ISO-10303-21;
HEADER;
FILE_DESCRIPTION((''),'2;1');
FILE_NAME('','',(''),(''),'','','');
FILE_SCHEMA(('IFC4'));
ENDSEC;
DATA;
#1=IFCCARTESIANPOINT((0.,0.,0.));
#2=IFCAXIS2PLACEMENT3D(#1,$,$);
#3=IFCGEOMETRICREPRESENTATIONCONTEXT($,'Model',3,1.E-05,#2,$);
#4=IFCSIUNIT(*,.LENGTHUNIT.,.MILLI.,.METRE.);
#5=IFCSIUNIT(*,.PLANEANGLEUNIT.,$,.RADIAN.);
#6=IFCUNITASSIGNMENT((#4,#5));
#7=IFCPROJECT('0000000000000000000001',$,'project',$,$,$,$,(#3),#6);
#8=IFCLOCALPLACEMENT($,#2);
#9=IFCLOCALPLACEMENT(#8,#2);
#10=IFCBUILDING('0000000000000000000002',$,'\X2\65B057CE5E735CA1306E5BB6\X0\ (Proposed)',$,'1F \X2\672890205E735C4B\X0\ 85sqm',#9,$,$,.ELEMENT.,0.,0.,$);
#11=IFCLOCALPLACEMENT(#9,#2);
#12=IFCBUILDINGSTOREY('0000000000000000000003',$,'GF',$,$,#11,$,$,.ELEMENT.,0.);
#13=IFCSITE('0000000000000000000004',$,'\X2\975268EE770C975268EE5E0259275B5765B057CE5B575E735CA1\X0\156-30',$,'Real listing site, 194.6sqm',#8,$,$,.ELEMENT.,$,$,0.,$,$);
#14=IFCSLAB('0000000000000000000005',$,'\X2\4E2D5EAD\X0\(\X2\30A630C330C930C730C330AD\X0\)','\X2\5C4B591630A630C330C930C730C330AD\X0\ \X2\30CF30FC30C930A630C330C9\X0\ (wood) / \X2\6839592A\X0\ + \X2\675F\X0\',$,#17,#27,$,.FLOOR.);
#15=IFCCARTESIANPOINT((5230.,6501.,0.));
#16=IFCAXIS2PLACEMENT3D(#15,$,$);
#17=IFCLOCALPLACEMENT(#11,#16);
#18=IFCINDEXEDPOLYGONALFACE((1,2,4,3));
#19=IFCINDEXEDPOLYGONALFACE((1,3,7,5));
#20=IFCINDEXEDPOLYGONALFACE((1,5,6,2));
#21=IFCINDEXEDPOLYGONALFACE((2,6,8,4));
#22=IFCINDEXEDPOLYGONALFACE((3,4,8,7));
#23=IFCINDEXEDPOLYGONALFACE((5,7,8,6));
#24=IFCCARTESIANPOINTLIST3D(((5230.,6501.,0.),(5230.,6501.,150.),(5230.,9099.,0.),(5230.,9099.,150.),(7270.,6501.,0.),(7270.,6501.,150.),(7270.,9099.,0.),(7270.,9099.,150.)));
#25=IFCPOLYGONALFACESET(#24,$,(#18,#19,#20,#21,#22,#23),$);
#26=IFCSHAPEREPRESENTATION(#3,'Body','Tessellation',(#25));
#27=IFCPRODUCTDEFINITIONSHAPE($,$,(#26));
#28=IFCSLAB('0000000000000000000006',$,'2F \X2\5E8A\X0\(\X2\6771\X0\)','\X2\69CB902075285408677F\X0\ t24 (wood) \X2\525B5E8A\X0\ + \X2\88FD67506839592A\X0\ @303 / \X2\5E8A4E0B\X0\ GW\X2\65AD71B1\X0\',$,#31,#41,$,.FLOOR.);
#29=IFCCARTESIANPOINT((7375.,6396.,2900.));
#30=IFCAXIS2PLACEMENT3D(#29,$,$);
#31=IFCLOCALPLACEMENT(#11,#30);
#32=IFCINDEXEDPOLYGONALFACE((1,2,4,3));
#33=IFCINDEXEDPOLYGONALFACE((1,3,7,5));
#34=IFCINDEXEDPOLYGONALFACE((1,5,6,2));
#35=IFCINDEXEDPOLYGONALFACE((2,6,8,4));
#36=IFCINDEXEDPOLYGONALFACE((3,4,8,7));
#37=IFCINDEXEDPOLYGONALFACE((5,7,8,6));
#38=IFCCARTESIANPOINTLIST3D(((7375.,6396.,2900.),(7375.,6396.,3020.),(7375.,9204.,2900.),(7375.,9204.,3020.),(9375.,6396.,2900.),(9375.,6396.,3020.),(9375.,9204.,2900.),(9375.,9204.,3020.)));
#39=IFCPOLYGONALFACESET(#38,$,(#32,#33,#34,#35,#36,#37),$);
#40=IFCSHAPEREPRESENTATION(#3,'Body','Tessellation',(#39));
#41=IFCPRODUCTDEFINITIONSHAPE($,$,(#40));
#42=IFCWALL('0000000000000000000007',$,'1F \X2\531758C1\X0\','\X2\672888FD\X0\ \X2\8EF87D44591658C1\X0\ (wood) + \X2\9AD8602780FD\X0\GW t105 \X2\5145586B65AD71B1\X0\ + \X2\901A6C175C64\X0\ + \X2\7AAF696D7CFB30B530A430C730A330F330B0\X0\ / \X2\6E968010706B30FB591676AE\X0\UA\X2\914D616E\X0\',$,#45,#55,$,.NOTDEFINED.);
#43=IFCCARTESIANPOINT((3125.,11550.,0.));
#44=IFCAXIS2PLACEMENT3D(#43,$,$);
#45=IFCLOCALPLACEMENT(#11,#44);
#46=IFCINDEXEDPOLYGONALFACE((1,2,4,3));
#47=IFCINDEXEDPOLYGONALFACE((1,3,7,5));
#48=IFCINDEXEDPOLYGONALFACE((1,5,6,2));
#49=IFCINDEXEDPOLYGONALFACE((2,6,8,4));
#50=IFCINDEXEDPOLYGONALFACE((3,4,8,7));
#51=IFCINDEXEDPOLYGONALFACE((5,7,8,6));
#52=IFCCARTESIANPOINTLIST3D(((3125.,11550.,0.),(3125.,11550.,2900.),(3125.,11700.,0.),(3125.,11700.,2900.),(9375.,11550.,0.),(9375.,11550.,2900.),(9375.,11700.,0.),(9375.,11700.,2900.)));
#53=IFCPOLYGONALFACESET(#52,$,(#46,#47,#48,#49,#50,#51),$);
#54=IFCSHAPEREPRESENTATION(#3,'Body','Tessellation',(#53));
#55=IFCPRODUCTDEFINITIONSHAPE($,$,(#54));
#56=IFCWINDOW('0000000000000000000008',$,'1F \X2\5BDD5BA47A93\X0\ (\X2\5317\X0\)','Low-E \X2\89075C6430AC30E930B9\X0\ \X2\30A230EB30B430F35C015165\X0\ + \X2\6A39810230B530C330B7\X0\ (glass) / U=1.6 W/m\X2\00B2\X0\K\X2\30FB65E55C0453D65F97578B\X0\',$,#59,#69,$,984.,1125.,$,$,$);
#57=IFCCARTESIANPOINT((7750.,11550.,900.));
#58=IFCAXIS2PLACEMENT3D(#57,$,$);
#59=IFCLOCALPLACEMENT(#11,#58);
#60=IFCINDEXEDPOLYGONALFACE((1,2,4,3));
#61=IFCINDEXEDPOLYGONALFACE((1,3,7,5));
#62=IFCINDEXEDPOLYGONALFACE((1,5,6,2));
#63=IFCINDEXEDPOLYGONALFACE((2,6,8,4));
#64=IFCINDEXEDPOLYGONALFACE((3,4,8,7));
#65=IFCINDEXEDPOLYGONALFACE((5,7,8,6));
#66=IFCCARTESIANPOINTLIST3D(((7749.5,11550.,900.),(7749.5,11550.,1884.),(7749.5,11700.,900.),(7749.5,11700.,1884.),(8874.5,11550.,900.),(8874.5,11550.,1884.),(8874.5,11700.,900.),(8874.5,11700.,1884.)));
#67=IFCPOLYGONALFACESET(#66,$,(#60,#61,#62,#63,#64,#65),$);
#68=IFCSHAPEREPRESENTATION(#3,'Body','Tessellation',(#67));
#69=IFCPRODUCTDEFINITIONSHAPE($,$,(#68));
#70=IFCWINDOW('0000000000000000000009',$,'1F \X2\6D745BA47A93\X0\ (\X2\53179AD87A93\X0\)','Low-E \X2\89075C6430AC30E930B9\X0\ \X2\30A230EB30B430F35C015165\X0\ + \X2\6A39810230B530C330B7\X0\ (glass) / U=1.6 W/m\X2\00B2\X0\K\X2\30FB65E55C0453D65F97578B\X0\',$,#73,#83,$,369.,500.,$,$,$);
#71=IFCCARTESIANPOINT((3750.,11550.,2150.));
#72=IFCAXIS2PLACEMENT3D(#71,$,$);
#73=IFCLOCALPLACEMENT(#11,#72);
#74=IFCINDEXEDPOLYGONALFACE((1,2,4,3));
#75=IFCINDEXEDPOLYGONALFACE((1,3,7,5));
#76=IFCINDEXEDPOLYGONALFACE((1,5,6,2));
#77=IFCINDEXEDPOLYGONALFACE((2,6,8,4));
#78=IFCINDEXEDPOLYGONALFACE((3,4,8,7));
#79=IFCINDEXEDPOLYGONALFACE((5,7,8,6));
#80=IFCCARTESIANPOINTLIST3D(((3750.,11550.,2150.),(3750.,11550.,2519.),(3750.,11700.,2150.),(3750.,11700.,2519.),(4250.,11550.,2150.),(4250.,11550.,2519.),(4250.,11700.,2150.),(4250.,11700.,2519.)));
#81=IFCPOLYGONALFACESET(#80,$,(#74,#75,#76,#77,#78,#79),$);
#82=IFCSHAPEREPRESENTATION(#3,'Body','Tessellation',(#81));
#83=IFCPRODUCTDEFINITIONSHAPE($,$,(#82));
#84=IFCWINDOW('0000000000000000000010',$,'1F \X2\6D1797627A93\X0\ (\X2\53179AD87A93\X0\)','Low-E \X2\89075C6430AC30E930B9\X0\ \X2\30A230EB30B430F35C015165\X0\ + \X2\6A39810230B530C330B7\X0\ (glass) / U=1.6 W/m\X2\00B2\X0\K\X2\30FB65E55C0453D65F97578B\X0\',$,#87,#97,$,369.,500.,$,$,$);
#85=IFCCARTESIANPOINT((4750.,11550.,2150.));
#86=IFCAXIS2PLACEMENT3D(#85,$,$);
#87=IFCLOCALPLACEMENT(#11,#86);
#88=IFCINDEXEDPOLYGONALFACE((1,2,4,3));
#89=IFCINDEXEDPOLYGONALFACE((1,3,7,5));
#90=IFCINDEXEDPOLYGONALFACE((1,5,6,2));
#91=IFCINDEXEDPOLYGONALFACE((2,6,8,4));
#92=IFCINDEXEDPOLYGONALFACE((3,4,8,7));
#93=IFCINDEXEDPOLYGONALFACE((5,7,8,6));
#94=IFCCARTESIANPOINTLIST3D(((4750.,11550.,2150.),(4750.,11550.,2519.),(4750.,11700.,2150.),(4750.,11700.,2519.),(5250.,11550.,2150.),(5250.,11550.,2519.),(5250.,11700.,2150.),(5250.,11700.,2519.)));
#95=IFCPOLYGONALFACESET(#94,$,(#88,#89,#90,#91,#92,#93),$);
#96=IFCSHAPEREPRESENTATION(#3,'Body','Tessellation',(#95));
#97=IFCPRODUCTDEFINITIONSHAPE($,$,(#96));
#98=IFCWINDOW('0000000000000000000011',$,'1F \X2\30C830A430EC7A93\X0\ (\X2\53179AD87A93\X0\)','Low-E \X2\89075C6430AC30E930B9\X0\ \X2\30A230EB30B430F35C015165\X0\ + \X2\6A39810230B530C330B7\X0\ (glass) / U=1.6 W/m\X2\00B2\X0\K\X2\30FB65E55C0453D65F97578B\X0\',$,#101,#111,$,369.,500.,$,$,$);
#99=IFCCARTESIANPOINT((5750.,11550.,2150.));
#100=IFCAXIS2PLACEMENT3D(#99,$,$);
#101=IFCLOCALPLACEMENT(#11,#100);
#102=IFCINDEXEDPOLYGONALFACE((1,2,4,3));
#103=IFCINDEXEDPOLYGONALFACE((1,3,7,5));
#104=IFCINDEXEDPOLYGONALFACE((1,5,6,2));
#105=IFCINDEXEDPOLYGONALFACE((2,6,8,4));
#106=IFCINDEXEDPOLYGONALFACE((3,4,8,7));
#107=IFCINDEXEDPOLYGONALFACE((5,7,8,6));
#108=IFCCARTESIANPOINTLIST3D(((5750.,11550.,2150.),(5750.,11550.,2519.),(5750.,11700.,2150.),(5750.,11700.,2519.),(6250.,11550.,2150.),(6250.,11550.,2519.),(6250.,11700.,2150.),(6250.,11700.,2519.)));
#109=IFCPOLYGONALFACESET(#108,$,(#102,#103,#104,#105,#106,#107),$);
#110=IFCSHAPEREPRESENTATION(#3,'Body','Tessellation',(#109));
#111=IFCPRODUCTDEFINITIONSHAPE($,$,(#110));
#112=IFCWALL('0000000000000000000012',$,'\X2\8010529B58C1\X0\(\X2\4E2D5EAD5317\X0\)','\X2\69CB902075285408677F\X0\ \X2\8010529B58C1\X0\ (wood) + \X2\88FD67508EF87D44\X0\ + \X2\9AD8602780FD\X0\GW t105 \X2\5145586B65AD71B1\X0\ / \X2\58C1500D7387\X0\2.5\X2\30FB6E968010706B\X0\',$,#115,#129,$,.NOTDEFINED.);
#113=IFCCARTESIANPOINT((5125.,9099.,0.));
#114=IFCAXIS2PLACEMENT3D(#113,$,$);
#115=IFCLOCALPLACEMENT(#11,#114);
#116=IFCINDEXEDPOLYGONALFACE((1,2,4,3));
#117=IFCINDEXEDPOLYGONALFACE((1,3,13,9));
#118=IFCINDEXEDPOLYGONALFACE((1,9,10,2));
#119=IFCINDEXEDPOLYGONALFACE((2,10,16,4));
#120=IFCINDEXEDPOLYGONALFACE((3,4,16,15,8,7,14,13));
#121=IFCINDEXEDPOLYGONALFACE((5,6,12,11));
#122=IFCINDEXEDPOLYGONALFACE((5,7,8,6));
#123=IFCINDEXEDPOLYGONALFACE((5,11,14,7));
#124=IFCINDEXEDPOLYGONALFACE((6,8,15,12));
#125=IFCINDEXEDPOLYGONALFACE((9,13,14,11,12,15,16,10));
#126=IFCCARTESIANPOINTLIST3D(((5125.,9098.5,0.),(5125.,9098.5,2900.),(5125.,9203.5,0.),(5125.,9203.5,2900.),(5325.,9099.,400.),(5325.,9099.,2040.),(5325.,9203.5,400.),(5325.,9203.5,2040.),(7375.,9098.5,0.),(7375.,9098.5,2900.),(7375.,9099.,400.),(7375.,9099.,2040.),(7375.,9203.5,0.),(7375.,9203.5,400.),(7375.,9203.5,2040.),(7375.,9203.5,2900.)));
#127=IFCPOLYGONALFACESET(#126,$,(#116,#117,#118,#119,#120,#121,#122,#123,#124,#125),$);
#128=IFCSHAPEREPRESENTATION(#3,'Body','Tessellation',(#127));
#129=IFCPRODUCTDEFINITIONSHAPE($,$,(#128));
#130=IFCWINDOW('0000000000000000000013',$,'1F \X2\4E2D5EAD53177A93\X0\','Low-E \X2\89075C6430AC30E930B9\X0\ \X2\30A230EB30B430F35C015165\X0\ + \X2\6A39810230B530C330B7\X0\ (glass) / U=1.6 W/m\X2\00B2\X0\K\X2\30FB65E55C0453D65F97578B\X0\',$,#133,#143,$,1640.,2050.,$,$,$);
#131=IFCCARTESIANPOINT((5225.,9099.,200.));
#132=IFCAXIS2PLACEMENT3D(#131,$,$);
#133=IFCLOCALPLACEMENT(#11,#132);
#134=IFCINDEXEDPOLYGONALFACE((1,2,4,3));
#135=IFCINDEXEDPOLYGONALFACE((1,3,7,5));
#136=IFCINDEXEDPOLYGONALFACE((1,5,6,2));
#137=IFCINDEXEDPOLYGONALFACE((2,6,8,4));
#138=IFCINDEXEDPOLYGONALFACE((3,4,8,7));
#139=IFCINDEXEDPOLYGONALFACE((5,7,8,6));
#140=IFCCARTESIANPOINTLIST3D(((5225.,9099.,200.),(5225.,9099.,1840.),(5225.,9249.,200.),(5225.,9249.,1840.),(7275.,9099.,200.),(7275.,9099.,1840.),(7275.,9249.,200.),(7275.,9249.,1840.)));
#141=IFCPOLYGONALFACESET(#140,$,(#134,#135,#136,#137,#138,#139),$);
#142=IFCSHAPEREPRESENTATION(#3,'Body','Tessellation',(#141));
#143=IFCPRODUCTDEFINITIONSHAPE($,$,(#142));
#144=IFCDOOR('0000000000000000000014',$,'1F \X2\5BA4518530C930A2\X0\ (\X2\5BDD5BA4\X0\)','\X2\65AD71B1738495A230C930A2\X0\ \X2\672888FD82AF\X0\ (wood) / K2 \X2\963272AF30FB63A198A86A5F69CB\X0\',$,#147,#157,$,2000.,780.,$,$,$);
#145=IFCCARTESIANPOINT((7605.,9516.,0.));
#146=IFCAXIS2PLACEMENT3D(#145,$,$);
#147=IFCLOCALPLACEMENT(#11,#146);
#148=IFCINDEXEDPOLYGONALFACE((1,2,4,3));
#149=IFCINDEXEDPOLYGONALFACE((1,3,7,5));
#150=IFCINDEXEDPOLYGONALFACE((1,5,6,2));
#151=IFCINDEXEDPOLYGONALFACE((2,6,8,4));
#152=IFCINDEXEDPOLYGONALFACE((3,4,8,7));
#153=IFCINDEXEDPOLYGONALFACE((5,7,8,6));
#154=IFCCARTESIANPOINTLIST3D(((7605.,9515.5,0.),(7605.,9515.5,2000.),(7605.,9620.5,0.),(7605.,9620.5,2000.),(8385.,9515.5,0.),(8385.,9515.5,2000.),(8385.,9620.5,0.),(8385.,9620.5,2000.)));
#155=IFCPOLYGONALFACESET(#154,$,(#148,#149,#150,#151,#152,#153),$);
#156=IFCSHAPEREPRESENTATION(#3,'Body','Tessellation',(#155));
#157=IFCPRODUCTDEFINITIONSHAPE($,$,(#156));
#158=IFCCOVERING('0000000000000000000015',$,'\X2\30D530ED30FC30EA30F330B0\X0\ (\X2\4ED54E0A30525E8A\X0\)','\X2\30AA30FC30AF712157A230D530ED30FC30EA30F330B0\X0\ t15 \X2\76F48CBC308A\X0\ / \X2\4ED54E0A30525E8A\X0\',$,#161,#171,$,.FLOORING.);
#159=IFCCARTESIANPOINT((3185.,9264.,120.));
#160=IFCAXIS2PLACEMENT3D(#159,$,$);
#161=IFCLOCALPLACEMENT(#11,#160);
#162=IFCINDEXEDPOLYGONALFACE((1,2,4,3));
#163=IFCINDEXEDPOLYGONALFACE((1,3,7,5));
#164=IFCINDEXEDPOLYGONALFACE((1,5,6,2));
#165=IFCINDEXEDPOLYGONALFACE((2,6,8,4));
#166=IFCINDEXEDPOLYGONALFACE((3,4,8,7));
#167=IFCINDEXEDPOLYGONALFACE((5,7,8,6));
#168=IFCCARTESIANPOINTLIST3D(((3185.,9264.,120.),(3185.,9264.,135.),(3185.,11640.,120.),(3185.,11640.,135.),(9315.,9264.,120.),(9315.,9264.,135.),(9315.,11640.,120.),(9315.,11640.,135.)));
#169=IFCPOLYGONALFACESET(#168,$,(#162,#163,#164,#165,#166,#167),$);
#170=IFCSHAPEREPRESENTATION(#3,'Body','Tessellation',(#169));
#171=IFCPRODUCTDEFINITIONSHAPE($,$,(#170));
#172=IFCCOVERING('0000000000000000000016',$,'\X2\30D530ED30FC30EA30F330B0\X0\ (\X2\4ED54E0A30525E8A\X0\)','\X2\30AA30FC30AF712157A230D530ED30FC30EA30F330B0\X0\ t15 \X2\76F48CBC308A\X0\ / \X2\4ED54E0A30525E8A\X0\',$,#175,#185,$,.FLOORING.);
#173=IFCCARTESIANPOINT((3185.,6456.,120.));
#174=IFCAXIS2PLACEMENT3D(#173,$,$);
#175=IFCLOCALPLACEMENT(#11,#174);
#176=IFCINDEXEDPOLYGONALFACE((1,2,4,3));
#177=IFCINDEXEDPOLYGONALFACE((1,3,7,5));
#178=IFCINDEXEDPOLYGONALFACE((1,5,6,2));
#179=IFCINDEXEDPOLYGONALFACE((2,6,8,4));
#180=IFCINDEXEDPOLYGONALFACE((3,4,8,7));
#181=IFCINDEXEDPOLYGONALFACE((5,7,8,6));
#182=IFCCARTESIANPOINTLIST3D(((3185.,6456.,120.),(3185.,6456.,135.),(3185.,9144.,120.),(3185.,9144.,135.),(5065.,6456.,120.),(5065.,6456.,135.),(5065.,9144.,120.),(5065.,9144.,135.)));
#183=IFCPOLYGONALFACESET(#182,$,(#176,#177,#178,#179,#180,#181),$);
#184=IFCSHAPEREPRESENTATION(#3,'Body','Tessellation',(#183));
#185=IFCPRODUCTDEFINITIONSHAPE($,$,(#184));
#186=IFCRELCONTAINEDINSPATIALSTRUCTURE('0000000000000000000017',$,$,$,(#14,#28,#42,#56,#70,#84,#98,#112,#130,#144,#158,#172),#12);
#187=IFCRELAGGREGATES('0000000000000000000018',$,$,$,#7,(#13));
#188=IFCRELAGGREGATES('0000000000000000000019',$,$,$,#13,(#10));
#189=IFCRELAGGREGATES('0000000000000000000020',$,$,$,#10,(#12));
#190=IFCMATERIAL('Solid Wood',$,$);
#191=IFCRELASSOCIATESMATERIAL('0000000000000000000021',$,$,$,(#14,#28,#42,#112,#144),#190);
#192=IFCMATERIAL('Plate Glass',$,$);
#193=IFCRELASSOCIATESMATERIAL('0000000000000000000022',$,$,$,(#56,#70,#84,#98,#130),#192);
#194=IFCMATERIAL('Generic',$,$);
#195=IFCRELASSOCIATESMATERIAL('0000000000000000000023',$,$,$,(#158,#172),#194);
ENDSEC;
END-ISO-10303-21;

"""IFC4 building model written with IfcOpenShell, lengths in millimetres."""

from ifc_helpers import new_model, si_unit, frame, frame_2d, origin, place, context, project, spatial, rectangle, extrude, material, element, fill, save


model = new_model("IFC4")

# Units and contexts
model_context = context("Model", 3, precision=1e-05, world=origin())
ifc_project = project(units=[si_unit("LENGTHUNIT", "METRE", prefix="MILLI"), si_unit("PLANEANGLEUNIT", "RADIAN")], contexts=[model_context])

# Site, building, storey
site_placement = place(None, origin())
site = spatial("IfcSite", under=ifc_project, at=site_placement, Name="青森県青森市大字新城字平岡156-30", ObjectType="Real listing site, 194.6sqm", CompositionType="ELEMENT", RefElevation=0.0)
building_placement = place(site_placement, origin())
building = spatial("IfcBuilding", under=site, at=building_placement, Name="新城平岡の家 (Proposed)", ObjectType="1F 木造平屋 85sqm", CompositionType="ELEMENT", ElevationOfRefHeight=0.0, ElevationOfTerrain=0.0)
storey_placement = place(building_placement, origin())
storey = spatial("IfcBuildingStorey", under=building, at=storey_placement, Name="GF", CompositionType="ELEMENT", Elevation=0.0)

# Slabs
ifc_material_1 = material(Name="Solid Wood")
slab_1_placement = place(storey_placement, frame((5230.0, 6501.0, 0.0)))
element("IfcSlab", 1, at=slab_1_placement, inside=storey, material=ifc_material_1, Name="中庭(ウッドデッキ)", Description="屋外ウッドデッキ ハードウッド (wood) / 根太 + 束", PredefinedType="FLOOR", context=model_context, shape_type="SweptSolid", body=[
    extrude(rectangle(XDim=2040.0, YDim=2598.0, at=frame_2d((1020.0, 1299.0))), frame((5230.0, 6501.0, 0.0)), (0.0, 0.0, 1.0), 150.0),
])
slab_2_placement = place(storey_placement, frame((7375.0, 6396.0, 2900.0)))
element("IfcSlab", 2, at=slab_2_placement, inside=storey, material=ifc_material_1, Name="2F 床(東)", Description="構造用合板 t24 (wood) 剛床 + 製材根太 @303 / 床下 GW断熱", PredefinedType="FLOOR", context=model_context, shape_type="SweptSolid", body=[
    extrude(rectangle(XDim=2000.0, YDim=2808.0, at=frame_2d((1000.0, 1404.0))), frame((7375.0, 6396.0, 2900.0)), (0.0, 0.0, 1.0), 120.0),
])

# Wall, openings, windows
wall_1_placement = place(storey_placement, frame((3125.0, 11550.0, 0.0)))
wall_1 = element("IfcWall", 3, at=wall_1_placement, inside=storey, material=ifc_material_1, Name="1F 北壁", Description="木製 軸組外壁 (wood) + 高性能GW t105 充填断熱 + 通気層 + 窯業系サイディング / 準耐火・外皮UA配慮", PredefinedType="NOTDEFINED", context=model_context, shape_type="SweptSolid", body=[
    extrude(rectangle(XDim=6250.0, YDim=150.0, at=frame_2d((3125.0, 75.0))), frame((3125.0, 11550.0, 0.0)), (0.0, 0.0, 1.0), 2900.0),
])
opening_1_placement = place(storey_placement, frame((7750.0, 11550.0, 900.0)))
opening_1 = element("IfcOpeningElement", 4, at=opening_1_placement, cuts=wall_1, PredefinedType="NOTDEFINED", context=model_context, shape_type="SweptSolid", body=[
    extrude(rectangle(XDim=1125.0, YDim=150.0, at=frame_2d((562.0, 75.0))), frame((7750.0, 11550.0, 900.0)), (0.0, 0.0, 1.0), 984.0),
])
opening_2_placement = place(storey_placement, frame((3750.0, 11550.0, 2150.0)))
opening_2 = element("IfcOpeningElement", 5, at=opening_2_placement, cuts=wall_1, PredefinedType="NOTDEFINED", context=model_context, shape_type="SweptSolid", body=[
    extrude(rectangle(XDim=500.0, YDim=150.0, at=frame_2d((250.0, 75.0))), frame((3750.0, 11550.0, 2150.0)), (0.0, 0.0, 1.0), 369.0),
])
opening_3_placement = place(storey_placement, frame((4750.0, 11550.0, 2150.0)))
opening_3 = element("IfcOpeningElement", 6, at=opening_3_placement, cuts=wall_1, PredefinedType="NOTDEFINED", context=model_context, shape_type="SweptSolid", body=[
    extrude(rectangle(XDim=500.0, YDim=150.0, at=frame_2d((250.0, 75.0))), frame((4750.0, 11550.0, 2150.0)), (0.0, 0.0, 1.0), 369.0),
])
opening_4_placement = place(storey_placement, frame((5750.0, 11550.0, 2150.0)))
opening_4 = element("IfcOpeningElement", 7, at=opening_4_placement, cuts=wall_1, PredefinedType="NOTDEFINED", context=model_context, shape_type="SweptSolid", body=[
    extrude(rectangle(XDim=500.0, YDim=150.0, at=frame_2d((250.0, 75.0))), frame((5750.0, 11550.0, 2150.0)), (0.0, 0.0, 1.0), 369.0),
])
ifc_material_2 = material(Name="Plate Glass")
window_1_placement = place(storey_placement, frame((7750.0, 11550.0, 900.0)))
window_1 = element("IfcWindow", 8, at=window_1_placement, inside=storey, material=ifc_material_2, Name="1F 寝室窓 (北)", Description="Low-E 複層ガラス アルゴン封入 + 樹脂サッシ (glass) / U=1.6 W/m²K・日射取得型", OverallHeight=984.0, OverallWidth=1125.0, context=model_context, shape_type="SweptSolid", body=[
    extrude(rectangle(XDim=1125.0, YDim=150.0, at=frame_2d((562.0, 75.0))), frame((7750.0, 11550.0, 900.0)), (0.0, 0.0, 1.0), 984.0),
])
fill(opening_1, window_1)
window_2_placement = place(storey_placement, frame((3750.0, 11550.0, 2150.0)))
window_2 = element("IfcWindow", 9, at=window_2_placement, inside=storey, material=ifc_material_2, Name="1F 浴室窓 (北高窓)", Description="Low-E 複層ガラス アルゴン封入 + 樹脂サッシ (glass) / U=1.6 W/m²K・日射取得型", OverallHeight=369.0, OverallWidth=500.0, context=model_context, shape_type="SweptSolid", body=[
    extrude(rectangle(XDim=500.0, YDim=150.0, at=frame_2d((250.0, 75.0))), frame((3750.0, 11550.0, 2150.0)), (0.0, 0.0, 1.0), 369.0),
])
fill(opening_2, window_2)
window_3_placement = place(storey_placement, frame((4750.0, 11550.0, 2150.0)))
window_3 = element("IfcWindow", 10, at=window_3_placement, inside=storey, material=ifc_material_2, Name="1F 洗面窓 (北高窓)", Description="Low-E 複層ガラス アルゴン封入 + 樹脂サッシ (glass) / U=1.6 W/m²K・日射取得型", OverallHeight=369.0, OverallWidth=500.0, context=model_context, shape_type="SweptSolid", body=[
    extrude(rectangle(XDim=500.0, YDim=150.0, at=frame_2d((250.0, 75.0))), frame((4750.0, 11550.0, 2150.0)), (0.0, 0.0, 1.0), 369.0),
])
fill(opening_3, window_3)
window_4_placement = place(storey_placement, frame((5750.0, 11550.0, 2150.0)))
window_4 = element("IfcWindow", 11, at=window_4_placement, inside=storey, material=ifc_material_2, Name="1F トイレ窓 (北高窓)", Description="Low-E 複層ガラス アルゴン封入 + 樹脂サッシ (glass) / U=1.6 W/m²K・日射取得型", OverallHeight=369.0, OverallWidth=500.0, context=model_context, shape_type="SweptSolid", body=[
    extrude(rectangle(XDim=500.0, YDim=150.0, at=frame_2d((250.0, 75.0))), frame((5750.0, 11550.0, 2150.0)), (0.0, 0.0, 1.0), 369.0),
])
fill(opening_4, window_4)

# Wall, opening, window
wall_2_placement = place(storey_placement, frame((5125.0, 9099.0, 0.0)))
wall_2 = element("IfcWall", 12, at=wall_2_placement, inside=storey, material=ifc_material_1, Name="耐力壁(中庭北)", Description="構造用合板 耐力壁 (wood) + 製材軸組 + 高性能GW t105 充填断熱 / 壁倍率2.5・準耐火", PredefinedType="NOTDEFINED", context=model_context, shape_type="SweptSolid", body=[
    extrude(rectangle(XDim=2250.0, YDim=105.0, at=frame_2d((1125.0, 52.0))), frame((5125.0, 9099.0, 0.0)), (0.0, 0.0, 1.0), 2900.0),
])
opening_5_placement = place(storey_placement, frame((5225.0, 9099.0, 200.0)))
opening_5 = element("IfcOpeningElement", 13, at=opening_5_placement, cuts=wall_2, PredefinedType="NOTDEFINED", context=model_context, shape_type="SweptSolid", body=[
    extrude(rectangle(XDim=2050.0, YDim=150.0, at=frame_2d((1025.0, 75.0))), frame((5225.0, 9099.0, 200.0)), (0.0, 0.0, 1.0), 1640.0),
])
window_5_placement = place(storey_placement, frame((5225.0, 9099.0, 200.0)))
window_5 = element("IfcWindow", 14, at=window_5_placement, inside=storey, material=ifc_material_2, Name="1F 中庭北窓", Description="Low-E 複層ガラス アルゴン封入 + 樹脂サッシ (glass) / U=1.6 W/m²K・日射取得型", OverallHeight=1640.0, OverallWidth=2050.0, context=model_context, shape_type="SweptSolid", body=[
    extrude(rectangle(XDim=2050.0, YDim=150.0, at=frame_2d((1025.0, 75.0))), frame((5225.0, 9099.0, 200.0)), (0.0, 0.0, 1.0), 1640.0),
])
fill(opening_5, window_5)

# Door
door_1_placement = place(storey_placement, frame((7605.0, 9516.0, 0.0)))
element("IfcDoor", 15, at=door_1_placement, inside=storey, material=ifc_material_1, Name="1F 室内ドア (寝室)", Description="断熱玄関ドア 木製芯 (wood) / K2 防犯・採風機構", OverallHeight=2000.0, OverallWidth=780.0, context=model_context, shape_type="SweptSolid", body=[
    extrude(rectangle(XDim=780.0, YDim=105.0, at=frame_2d((390.0, 52.0))), frame((7605.0, 9516.0, 0.0)), (0.0, 0.0, 1.0), 2000.0),
])

# Coverings
ifc_material_3 = material(Name="Generic")
covering_1_placement = place(storey_placement, frame((3185.0, 9264.0, 120.0)))
element("IfcCovering", 16, at=covering_1_placement, inside=storey, material=ifc_material_3, Name="フローリング (仕上げ床)", Description="オーク無垢フローリング t15 直貼り / 仕上げ床", PredefinedType="FLOORING", context=model_context, shape_type="SweptSolid", body=[
    extrude(rectangle(XDim=6130.0, YDim=2376.0, at=frame_2d((3065.0, 1188.0))), frame((3185.0, 9264.0, 120.0)), (0.0, 0.0, 1.0), 15.0),
])
covering_2_placement = place(storey_placement, frame((3185.0, 6456.0, 120.0)))
element("IfcCovering", 17, at=covering_2_placement, inside=storey, material=ifc_material_3, Name="フローリング (仕上げ床)", Description="オーク無垢フローリング t15 直貼り / 仕上げ床", PredefinedType="FLOORING", context=model_context, shape_type="SweptSolid", body=[
    extrude(rectangle(XDim=1880.0, YDim=2688.0, at=frame_2d((940.0, 1344.0))), frame((3185.0, 6456.0, 120.0)), (0.0, 0.0, 1.0), 15.0),
])

save(model, "model.ifc")
